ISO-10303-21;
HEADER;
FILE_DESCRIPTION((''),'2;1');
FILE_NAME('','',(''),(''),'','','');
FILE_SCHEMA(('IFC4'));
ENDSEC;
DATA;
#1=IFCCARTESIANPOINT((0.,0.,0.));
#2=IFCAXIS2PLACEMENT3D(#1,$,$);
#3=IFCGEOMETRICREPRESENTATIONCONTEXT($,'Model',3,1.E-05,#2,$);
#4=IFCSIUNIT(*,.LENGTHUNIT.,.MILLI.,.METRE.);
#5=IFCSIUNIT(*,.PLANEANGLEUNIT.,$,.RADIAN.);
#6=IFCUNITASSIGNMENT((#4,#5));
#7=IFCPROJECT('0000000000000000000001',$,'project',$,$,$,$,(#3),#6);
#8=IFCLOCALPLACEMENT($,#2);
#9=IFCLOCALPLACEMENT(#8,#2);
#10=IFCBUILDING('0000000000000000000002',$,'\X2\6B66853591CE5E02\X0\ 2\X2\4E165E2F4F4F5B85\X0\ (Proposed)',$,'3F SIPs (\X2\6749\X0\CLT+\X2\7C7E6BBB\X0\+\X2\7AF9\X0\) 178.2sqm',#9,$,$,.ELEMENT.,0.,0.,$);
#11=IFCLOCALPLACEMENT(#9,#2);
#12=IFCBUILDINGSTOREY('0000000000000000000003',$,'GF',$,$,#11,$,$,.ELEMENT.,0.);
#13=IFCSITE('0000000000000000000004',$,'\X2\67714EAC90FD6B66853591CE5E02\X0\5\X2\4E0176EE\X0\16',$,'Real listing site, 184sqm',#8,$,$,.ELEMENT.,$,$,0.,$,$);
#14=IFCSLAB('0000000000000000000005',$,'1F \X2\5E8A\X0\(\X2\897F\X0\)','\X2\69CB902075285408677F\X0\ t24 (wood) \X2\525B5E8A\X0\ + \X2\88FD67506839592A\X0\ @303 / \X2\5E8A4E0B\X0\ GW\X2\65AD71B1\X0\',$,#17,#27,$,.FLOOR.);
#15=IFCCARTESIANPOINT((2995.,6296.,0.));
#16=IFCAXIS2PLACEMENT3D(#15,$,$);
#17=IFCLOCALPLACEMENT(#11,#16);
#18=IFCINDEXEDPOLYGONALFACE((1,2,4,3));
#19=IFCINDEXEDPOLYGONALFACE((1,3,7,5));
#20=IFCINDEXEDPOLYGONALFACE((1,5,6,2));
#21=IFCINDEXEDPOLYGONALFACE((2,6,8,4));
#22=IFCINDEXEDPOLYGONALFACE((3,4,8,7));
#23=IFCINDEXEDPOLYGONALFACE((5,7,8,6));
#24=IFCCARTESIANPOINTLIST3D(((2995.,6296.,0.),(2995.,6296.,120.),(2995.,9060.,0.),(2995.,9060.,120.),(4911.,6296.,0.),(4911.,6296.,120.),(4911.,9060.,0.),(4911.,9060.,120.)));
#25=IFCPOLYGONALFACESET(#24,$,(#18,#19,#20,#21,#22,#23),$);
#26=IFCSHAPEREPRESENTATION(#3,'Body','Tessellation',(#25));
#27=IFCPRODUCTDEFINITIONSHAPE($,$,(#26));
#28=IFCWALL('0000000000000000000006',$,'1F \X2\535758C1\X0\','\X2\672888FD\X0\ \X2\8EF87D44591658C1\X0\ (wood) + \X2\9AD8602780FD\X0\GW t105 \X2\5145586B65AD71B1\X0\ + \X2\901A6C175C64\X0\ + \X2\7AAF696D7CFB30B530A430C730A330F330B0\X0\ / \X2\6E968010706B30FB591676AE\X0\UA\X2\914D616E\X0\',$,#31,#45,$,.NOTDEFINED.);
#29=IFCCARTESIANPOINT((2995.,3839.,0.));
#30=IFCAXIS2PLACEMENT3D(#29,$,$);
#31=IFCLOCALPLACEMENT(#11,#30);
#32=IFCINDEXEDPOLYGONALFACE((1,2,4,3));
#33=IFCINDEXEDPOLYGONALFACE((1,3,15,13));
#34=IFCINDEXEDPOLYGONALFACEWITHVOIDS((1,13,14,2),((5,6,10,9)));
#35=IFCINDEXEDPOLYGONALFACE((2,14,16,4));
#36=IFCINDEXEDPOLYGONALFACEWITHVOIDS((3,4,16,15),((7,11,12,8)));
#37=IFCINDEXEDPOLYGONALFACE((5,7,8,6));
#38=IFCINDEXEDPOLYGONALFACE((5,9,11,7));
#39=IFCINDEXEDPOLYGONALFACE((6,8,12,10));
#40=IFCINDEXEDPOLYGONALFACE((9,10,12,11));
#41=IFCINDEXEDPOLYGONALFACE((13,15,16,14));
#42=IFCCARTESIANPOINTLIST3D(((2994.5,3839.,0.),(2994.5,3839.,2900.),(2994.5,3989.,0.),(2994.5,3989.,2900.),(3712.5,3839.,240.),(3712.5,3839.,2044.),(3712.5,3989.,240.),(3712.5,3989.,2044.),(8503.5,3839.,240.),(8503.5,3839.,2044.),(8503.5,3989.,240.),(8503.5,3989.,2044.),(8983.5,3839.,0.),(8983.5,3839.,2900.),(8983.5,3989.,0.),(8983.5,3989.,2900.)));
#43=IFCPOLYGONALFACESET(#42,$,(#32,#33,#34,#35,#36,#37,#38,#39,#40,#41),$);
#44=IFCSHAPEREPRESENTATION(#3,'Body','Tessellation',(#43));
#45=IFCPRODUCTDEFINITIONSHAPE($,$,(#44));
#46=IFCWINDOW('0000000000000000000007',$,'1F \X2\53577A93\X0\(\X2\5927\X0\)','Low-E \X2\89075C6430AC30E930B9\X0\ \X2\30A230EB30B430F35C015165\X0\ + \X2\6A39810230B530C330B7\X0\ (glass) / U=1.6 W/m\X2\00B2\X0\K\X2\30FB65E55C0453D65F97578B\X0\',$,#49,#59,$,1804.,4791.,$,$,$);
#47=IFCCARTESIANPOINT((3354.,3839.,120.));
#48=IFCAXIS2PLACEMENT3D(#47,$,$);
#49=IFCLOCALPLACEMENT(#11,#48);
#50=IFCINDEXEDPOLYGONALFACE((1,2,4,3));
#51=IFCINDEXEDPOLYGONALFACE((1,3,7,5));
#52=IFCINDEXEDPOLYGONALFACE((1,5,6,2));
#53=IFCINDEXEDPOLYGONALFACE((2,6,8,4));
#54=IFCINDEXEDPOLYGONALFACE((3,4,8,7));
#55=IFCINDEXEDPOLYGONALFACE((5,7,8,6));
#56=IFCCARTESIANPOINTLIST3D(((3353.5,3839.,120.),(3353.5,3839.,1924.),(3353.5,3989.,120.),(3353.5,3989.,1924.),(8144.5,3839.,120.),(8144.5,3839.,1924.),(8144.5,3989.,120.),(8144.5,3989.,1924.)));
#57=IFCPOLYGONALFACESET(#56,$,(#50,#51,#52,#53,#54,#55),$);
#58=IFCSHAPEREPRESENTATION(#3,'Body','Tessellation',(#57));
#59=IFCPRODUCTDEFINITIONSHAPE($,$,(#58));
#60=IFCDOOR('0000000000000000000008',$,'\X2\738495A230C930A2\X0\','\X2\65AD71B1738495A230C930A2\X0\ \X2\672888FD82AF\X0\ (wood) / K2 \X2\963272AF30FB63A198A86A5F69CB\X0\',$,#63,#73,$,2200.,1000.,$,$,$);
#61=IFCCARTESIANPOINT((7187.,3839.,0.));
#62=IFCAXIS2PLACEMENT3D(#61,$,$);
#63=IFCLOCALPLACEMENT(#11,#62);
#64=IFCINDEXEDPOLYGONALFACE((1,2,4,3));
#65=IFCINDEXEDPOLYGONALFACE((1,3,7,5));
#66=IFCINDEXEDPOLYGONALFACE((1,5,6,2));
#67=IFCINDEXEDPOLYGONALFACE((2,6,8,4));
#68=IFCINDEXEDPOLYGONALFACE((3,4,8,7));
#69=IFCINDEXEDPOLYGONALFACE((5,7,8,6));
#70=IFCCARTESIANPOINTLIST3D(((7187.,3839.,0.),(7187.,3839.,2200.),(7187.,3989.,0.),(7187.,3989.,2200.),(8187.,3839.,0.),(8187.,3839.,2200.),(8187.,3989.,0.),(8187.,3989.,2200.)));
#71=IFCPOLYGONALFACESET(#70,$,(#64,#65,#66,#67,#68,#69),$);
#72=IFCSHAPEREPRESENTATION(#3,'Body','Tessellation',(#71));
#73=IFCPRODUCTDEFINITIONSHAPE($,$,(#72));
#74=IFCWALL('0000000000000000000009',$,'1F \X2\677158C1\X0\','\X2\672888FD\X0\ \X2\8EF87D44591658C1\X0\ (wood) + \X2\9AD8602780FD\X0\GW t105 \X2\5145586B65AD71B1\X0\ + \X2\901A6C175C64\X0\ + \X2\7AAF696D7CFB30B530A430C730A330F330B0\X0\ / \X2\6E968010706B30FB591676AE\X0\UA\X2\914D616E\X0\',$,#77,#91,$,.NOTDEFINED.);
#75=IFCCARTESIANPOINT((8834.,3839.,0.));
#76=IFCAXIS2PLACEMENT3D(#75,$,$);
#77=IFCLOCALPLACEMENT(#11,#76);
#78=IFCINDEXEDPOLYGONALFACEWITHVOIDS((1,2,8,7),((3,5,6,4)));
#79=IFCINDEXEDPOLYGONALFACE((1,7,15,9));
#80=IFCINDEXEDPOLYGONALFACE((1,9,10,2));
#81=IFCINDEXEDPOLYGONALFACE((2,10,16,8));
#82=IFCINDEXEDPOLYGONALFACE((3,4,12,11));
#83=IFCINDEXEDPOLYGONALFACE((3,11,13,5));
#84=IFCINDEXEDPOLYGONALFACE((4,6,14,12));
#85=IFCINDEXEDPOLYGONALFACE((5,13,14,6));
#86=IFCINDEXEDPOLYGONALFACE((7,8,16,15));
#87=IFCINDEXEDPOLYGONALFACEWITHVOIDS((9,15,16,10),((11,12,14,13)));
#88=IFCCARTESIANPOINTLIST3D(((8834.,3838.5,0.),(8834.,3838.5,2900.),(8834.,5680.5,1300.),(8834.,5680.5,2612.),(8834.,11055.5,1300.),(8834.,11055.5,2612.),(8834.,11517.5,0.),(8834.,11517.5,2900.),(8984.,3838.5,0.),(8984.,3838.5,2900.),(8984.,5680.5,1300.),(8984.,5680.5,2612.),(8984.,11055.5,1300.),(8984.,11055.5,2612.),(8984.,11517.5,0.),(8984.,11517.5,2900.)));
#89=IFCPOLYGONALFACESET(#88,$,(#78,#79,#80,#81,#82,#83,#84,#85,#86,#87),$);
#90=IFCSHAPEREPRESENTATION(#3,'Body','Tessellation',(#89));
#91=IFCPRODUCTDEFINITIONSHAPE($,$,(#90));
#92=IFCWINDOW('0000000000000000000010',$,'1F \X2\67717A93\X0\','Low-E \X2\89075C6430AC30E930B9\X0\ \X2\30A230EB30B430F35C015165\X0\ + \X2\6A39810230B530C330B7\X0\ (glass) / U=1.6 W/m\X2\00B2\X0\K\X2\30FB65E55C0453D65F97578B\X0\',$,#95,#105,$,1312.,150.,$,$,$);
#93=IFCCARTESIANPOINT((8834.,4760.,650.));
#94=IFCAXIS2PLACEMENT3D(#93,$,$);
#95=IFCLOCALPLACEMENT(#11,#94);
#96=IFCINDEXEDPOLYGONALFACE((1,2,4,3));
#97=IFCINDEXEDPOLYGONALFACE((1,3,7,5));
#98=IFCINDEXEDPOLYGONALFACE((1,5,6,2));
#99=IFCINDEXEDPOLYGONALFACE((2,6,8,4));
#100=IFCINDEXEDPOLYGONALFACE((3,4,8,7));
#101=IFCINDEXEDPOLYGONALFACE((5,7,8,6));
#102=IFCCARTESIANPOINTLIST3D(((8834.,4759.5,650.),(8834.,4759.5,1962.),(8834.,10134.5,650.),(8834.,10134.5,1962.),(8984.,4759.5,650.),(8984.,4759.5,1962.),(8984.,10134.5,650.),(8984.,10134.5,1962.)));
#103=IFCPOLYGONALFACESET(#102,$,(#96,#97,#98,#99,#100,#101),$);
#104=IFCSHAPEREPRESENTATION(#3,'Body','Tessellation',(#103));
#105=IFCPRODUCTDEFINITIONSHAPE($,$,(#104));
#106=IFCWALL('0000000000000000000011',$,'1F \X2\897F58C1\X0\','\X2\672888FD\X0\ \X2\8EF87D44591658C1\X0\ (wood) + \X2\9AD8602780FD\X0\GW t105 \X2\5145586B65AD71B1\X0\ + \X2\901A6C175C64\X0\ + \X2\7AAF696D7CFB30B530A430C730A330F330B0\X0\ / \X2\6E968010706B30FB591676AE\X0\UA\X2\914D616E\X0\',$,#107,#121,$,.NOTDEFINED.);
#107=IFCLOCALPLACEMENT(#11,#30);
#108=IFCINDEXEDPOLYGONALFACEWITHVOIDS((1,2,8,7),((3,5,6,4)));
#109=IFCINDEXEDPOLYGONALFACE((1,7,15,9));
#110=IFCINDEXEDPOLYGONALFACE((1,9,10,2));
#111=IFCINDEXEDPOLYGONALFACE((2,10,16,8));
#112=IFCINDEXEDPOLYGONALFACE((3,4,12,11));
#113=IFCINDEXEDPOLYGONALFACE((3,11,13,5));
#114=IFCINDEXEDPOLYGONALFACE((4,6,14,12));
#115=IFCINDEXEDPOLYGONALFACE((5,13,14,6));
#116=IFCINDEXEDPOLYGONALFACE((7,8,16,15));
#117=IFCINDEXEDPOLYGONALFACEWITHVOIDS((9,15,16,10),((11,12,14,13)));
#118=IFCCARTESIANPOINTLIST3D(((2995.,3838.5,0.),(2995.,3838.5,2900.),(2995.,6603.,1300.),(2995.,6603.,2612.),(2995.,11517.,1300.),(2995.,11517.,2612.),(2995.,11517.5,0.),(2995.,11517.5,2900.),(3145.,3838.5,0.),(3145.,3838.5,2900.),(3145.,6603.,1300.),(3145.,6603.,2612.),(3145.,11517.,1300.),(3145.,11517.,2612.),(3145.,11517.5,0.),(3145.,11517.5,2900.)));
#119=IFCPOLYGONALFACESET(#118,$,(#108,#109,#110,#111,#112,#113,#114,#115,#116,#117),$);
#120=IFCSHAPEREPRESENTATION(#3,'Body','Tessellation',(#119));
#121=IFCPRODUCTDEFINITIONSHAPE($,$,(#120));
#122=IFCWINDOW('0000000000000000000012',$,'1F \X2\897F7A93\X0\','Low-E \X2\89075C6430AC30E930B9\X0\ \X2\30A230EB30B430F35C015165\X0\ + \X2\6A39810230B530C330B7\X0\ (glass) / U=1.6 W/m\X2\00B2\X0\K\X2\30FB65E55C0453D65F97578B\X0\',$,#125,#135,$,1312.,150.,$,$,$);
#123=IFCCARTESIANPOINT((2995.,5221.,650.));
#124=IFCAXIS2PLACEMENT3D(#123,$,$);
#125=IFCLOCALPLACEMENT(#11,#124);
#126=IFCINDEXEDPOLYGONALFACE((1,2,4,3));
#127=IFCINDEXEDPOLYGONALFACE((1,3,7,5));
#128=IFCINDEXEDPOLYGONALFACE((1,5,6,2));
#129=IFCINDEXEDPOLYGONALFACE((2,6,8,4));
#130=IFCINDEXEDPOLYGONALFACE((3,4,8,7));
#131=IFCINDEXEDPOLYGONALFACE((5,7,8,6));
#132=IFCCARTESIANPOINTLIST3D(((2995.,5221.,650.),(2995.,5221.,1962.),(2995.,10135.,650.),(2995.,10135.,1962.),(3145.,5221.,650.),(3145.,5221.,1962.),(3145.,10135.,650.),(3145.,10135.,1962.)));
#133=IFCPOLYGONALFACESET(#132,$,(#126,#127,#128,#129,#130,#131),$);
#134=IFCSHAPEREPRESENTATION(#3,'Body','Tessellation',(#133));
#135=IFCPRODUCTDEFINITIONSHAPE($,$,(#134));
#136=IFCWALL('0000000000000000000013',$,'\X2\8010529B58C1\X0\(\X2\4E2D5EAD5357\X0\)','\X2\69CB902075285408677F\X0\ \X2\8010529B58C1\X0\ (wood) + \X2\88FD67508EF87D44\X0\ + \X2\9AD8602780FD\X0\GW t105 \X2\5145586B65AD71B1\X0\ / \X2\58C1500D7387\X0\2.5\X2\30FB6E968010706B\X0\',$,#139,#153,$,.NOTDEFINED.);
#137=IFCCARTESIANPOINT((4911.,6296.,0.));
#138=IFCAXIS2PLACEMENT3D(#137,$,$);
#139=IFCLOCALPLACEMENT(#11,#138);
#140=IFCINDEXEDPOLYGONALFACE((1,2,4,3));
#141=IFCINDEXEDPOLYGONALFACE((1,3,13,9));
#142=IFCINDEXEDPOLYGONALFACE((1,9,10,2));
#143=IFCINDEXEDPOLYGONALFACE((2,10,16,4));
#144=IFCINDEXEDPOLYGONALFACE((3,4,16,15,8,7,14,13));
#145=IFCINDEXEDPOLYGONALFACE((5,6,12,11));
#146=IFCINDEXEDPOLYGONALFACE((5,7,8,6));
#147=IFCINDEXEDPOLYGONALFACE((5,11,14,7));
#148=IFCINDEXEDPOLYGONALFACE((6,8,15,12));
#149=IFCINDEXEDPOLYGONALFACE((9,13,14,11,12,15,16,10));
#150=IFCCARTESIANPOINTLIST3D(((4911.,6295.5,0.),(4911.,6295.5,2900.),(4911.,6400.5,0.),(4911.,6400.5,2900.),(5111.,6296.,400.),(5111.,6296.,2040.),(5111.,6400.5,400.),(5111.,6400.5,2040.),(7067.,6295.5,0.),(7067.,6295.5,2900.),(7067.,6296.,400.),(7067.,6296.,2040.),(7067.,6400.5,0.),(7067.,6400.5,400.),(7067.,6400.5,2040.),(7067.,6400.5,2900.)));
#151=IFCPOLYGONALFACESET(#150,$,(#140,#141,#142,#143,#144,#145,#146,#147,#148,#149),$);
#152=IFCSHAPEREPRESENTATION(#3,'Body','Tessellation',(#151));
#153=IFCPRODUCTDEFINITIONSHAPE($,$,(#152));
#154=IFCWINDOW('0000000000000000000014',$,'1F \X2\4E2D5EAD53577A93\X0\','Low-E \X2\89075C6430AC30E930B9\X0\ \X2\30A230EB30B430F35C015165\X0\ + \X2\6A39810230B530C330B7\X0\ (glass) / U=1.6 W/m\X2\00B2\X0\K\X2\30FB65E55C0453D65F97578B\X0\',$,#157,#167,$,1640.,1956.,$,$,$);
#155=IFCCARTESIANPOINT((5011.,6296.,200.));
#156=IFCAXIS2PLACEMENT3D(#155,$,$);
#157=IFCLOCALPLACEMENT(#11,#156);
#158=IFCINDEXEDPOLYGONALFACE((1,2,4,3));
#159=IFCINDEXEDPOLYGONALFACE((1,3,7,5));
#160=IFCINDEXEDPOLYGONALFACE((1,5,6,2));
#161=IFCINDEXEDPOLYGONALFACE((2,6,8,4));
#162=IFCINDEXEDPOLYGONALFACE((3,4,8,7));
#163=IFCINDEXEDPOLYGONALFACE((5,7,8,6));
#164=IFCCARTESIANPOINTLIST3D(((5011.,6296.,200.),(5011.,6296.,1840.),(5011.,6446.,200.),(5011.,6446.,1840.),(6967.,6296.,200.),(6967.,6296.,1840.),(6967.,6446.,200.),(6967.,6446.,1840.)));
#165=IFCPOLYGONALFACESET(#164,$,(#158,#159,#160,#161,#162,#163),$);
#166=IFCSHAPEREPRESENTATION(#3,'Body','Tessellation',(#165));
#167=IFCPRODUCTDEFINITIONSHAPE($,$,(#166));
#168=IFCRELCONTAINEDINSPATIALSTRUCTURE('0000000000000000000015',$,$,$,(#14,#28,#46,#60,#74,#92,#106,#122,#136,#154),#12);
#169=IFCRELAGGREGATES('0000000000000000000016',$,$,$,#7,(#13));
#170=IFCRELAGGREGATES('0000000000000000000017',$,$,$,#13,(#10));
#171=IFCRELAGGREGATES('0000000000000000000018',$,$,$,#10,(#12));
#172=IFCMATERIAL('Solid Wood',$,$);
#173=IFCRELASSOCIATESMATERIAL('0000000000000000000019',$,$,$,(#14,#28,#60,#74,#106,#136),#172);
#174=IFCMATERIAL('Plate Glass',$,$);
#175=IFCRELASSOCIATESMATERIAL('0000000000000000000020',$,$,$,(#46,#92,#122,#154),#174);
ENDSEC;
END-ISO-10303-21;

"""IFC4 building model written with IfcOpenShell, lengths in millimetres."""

from ifc_helpers import new_model, si_unit, frame, frame_2d, origin, place, context, project, spatial, rectangle, extrude, material, element, fill, save


model = new_model("IFC4")

# Units and contexts
model_context = context("Model", 3, precision=1e-05, world=origin())
ifc_project = project(units=[si_unit("LENGTHUNIT", "METRE", prefix="MILLI"), si_unit("PLANEANGLEUNIT", "RADIAN")], contexts=[model_context])

# Site, building, storey
site_placement = place(None, origin())
site = spatial("IfcSite", under=ifc_project, at=site_placement, Name="東京都武蔵野市5丁目16", ObjectType="Real listing site, 184sqm", CompositionType="ELEMENT", RefElevation=0.0)
building_placement = place(site_placement, origin())
building = spatial("IfcBuilding", under=site, at=building_placement, Name="武蔵野市 2世帯住宅 (Proposed)", ObjectType="3F SIPs (杉CLT+籾殻+竹) 178.2sqm", CompositionType="ELEMENT", ElevationOfRefHeight=0.0, ElevationOfTerrain=0.0)
storey_placement = place(building_placement, origin())
storey = spatial("IfcBuildingStorey", under=building, at=storey_placement, Name="GF", CompositionType="ELEMENT", Elevation=0.0)

# Slab
ifc_material_1 = material(Name="Solid Wood")
slab_1_placement = place(storey_placement, frame((2995.0, 6296.0, 0.0)))
element("IfcSlab", 1, at=slab_1_placement, inside=storey, material=ifc_material_1, Name="1F 床(西)", Description="構造用合板 t24 (wood) 剛床 + 製材根太 @303 / 床下 GW断熱", PredefinedType="FLOOR", context=model_context, shape_type="SweptSolid", body=[
    extrude(rectangle(XDim=1916.0, YDim=2764.0, at=frame_2d((958.0, 1382.0))), frame((2995.0, 6296.0, 0.0)), (0.0, 0.0, 1.0), 120.0),
])

# Wall, openings, window, door
wall_1_placement = place(storey_placement, frame((2995.0, 3839.0, 0.0)))
wall_1 = element("IfcWall", 2, at=wall_1_placement, inside=storey, material=ifc_material_1, Name="1F 南壁", Description="木製 軸組外壁 (wood) + 高性能GW t105 充填断熱 + 通気層 + 窯業系サイディング / 準耐火・外皮UA配慮", PredefinedType="NOTDEFINED", context=model_context, shape_type="SweptSolid", body=[
    extrude(rectangle(XDim=5989.0, YDim=150.0, at=frame_2d((2994.0, 75.0))), frame((2995.0, 3839.0, 0.0)), (0.0, 0.0, 1.0), 2900.0),
])
opening_1_placement = place(storey_placement, frame((3354.0, 3839.0, 120.0)))
opening_1 = element("IfcOpeningElement", 3, at=opening_1_placement, cuts=wall_1, PredefinedType="NOTDEFINED", context=model_context, shape_type="SweptSolid", body=[
    extrude(rectangle(XDim=4791.0, YDim=150.0, at=frame_2d((2395.0, 75.0))), frame((3354.0, 3839.0, 120.0)), (0.0, 0.0, 1.0), 1804.0),
])
opening_2_placement = place(storey_placement, frame((7187.0, 3839.0, 0.0)))
opening_2 = element("IfcOpeningElement", 4, at=opening_2_placement, cuts=wall_1, PredefinedType="NOTDEFINED", context=model_context, shape_type="SweptSolid", body=[
    extrude(rectangle(XDim=1000.0, YDim=150.0, at=frame_2d((500.0, 75.0))), frame((7187.0, 3839.0, 0.0)), (0.0, 0.0, 1.0), 2200.0),
])
ifc_material_2 = material(Name="Plate Glass")
window_1_placement = place(storey_placement, frame((3354.0, 3839.0, 120.0)))
window_1 = element("IfcWindow", 5, at=window_1_placement, inside=storey, material=ifc_material_2, Name="1F 南窓(大)", Description="Low-E 複層ガラス アルゴン封入 + 樹脂サッシ (glass) / U=1.6 W/m²K・日射取得型", OverallHeight=1804.0, OverallWidth=4791.0, context=model_context, shape_type="SweptSolid", body=[
    extrude(rectangle(XDim=4791.0, YDim=150.0, at=frame_2d((2395.0, 75.0))), frame((3354.0, 3839.0, 120.0)), (0.0, 0.0, 1.0), 1804.0),
])
fill(opening_1, window_1)
door_placement = place(storey_placement, frame((7187.0, 3839.0, 0.0)))
door = element("IfcDoor", 6, at=door_placement, inside=storey, material=ifc_material_1, Name="玄関ドア", Description="断熱玄関ドア 木製芯 (wood) / K2 防犯・採風機構", OverallHeight=2200.0, OverallWidth=1000.0, context=model_context, shape_type="SweptSolid", body=[
    extrude(rectangle(XDim=1000.0, YDim=150.0, at=frame_2d((500.0, 75.0))), frame((7187.0, 3839.0, 0.0)), (0.0, 0.0, 1.0), 2200.0),
])
fill(opening_2, door)

# Walls, openings, windows
wall_2_placement = place(storey_placement, frame((8834.0, 3839.0, 0.0)))
wall_2 = element("IfcWall", 7, at=wall_2_placement, inside=storey, material=ifc_material_1, Name="1F 東壁", Description="木製 軸組外壁 (wood) + 高性能GW t105 充填断熱 + 通気層 + 窯業系サイディング / 準耐火・外皮UA配慮", PredefinedType="NOTDEFINED", context=model_context, shape_type="SweptSolid", body=[
    extrude(rectangle(XDim=150.0, YDim=7679.0, at=frame_2d((75.0, 3839.0))), frame((8834.0, 3839.0, 0.0)), (0.0, 0.0, 1.0), 2900.0),
])
opening_3_placement = place(storey_placement, frame((8834.0, 4760.0, 650.0)))
opening_3 = element("IfcOpeningElement", 8, at=opening_3_placement, cuts=wall_2, PredefinedType="NOTDEFINED", context=model_context, shape_type="SweptSolid", body=[
    extrude(rectangle(XDim=150.0, YDim=5375.0, at=frame_2d((75.0, 2687.0))), frame((8834.0, 4760.0, 650.0)), (0.0, 0.0, 1.0), 1312.0),
])
window_2_placement = place(storey_placement, frame((8834.0, 4760.0, 650.0)))
window_2 = element("IfcWindow", 9, at=window_2_placement, inside=storey, material=ifc_material_2, Name="1F 東窓", Description="Low-E 複層ガラス アルゴン封入 + 樹脂サッシ (glass) / U=1.6 W/m²K・日射取得型", OverallHeight=1312.0, OverallWidth=150.0, context=model_context, shape_type="SweptSolid", body=[
    extrude(rectangle(XDim=150.0, YDim=5375.0, at=frame_2d((75.0, 2687.0))), frame((8834.0, 4760.0, 650.0)), (0.0, 0.0, 1.0), 1312.0),
])
fill(opening_3, window_2)
wall_3_placement = place(storey_placement, frame((2995.0, 3839.0, 0.0)))
wall_3 = element("IfcWall", 10, at=wall_3_placement, inside=storey, material=ifc_material_1, Name="1F 西壁", Description="木製 軸組外壁 (wood) + 高性能GW t105 充填断熱 + 通気層 + 窯業系サイディング / 準耐火・外皮UA配慮", PredefinedType="NOTDEFINED", context=model_context, shape_type="SweptSolid", body=[
    extrude(rectangle(XDim=150.0, YDim=7679.0, at=frame_2d((75.0, 3839.0))), frame((2995.0, 3839.0, 0.0)), (0.0, 0.0, 1.0), 2900.0),
])
opening_4_placement = place(storey_placement, frame((2995.0, 5221.0, 650.0)))
opening_4 = element("IfcOpeningElement", 11, at=opening_4_placement, cuts=wall_3, PredefinedType="NOTDEFINED", context=model_context, shape_type="SweptSolid", body=[
    extrude(rectangle(XDim=150.0, YDim=4914.0, at=frame_2d((75.0, 2457.0))), frame((2995.0, 5221.0, 650.0)), (0.0, 0.0, 1.0), 1312.0),
])
window_3_placement = place(storey_placement, frame((2995.0, 5221.0, 650.0)))
window_3 = element("IfcWindow", 12, at=window_3_placement, inside=storey, material=ifc_material_2, Name="1F 西窓", Description="Low-E 複層ガラス アルゴン封入 + 樹脂サッシ (glass) / U=1.6 W/m²K・日射取得型", OverallHeight=1312.0, OverallWidth=150.0, context=model_context, shape_type="SweptSolid", body=[
    extrude(rectangle(XDim=150.0, YDim=4914.0, at=frame_2d((75.0, 2457.0))), frame((2995.0, 5221.0, 650.0)), (0.0, 0.0, 1.0), 1312.0),
])
fill(opening_4, window_3)
wall_4_placement = place(storey_placement, frame((4911.0, 6296.0, 0.0)))
wall_4 = element("IfcWall", 13, at=wall_4_placement, inside=storey, material=ifc_material_1, Name="耐力壁(中庭南)", Description="構造用合板 耐力壁 (wood) + 製材軸組 + 高性能GW t105 充填断熱 / 壁倍率2.5・準耐火", PredefinedType="NOTDEFINED", context=model_context, shape_type="SweptSolid", body=[
    extrude(rectangle(XDim=2156.0, YDim=105.0, at=frame_2d((1078.0, 52.0))), frame((4911.0, 6296.0, 0.0)), (0.0, 0.0, 1.0), 2900.0),
])
opening_5_placement = place(storey_placement, frame((5011.0, 6296.0, 200.0)))
opening_5 = element("IfcOpeningElement", 14, at=opening_5_placement, cuts=wall_4, PredefinedType="NOTDEFINED", context=model_context, shape_type="SweptSolid", body=[
    extrude(rectangle(XDim=1956.0, YDim=150.0, at=frame_2d((978.0, 75.0))), frame((5011.0, 6296.0, 200.0)), (0.0, 0.0, 1.0), 1640.0),
])
window_4_placement = place(storey_placement, frame((5011.0, 6296.0, 200.0)))
window_4 = element("IfcWindow", 15, at=window_4_placement, inside=storey, material=ifc_material_2, Name="1F 中庭南窓", Description="Low-E 複層ガラス アルゴン封入 + 樹脂サッシ (glass) / U=1.6 W/m²K・日射取得型", OverallHeight=1640.0, OverallWidth=1956.0, context=model_context, shape_type="SweptSolid", body=[
    extrude(rectangle(XDim=1956.0, YDim=150.0, at=frame_2d((978.0, 75.0))), frame((5011.0, 6296.0, 200.0)), (0.0, 0.0, 1.0), 1640.0),
])
fill(opening_5, window_4)

save(model, "model.ifc")
